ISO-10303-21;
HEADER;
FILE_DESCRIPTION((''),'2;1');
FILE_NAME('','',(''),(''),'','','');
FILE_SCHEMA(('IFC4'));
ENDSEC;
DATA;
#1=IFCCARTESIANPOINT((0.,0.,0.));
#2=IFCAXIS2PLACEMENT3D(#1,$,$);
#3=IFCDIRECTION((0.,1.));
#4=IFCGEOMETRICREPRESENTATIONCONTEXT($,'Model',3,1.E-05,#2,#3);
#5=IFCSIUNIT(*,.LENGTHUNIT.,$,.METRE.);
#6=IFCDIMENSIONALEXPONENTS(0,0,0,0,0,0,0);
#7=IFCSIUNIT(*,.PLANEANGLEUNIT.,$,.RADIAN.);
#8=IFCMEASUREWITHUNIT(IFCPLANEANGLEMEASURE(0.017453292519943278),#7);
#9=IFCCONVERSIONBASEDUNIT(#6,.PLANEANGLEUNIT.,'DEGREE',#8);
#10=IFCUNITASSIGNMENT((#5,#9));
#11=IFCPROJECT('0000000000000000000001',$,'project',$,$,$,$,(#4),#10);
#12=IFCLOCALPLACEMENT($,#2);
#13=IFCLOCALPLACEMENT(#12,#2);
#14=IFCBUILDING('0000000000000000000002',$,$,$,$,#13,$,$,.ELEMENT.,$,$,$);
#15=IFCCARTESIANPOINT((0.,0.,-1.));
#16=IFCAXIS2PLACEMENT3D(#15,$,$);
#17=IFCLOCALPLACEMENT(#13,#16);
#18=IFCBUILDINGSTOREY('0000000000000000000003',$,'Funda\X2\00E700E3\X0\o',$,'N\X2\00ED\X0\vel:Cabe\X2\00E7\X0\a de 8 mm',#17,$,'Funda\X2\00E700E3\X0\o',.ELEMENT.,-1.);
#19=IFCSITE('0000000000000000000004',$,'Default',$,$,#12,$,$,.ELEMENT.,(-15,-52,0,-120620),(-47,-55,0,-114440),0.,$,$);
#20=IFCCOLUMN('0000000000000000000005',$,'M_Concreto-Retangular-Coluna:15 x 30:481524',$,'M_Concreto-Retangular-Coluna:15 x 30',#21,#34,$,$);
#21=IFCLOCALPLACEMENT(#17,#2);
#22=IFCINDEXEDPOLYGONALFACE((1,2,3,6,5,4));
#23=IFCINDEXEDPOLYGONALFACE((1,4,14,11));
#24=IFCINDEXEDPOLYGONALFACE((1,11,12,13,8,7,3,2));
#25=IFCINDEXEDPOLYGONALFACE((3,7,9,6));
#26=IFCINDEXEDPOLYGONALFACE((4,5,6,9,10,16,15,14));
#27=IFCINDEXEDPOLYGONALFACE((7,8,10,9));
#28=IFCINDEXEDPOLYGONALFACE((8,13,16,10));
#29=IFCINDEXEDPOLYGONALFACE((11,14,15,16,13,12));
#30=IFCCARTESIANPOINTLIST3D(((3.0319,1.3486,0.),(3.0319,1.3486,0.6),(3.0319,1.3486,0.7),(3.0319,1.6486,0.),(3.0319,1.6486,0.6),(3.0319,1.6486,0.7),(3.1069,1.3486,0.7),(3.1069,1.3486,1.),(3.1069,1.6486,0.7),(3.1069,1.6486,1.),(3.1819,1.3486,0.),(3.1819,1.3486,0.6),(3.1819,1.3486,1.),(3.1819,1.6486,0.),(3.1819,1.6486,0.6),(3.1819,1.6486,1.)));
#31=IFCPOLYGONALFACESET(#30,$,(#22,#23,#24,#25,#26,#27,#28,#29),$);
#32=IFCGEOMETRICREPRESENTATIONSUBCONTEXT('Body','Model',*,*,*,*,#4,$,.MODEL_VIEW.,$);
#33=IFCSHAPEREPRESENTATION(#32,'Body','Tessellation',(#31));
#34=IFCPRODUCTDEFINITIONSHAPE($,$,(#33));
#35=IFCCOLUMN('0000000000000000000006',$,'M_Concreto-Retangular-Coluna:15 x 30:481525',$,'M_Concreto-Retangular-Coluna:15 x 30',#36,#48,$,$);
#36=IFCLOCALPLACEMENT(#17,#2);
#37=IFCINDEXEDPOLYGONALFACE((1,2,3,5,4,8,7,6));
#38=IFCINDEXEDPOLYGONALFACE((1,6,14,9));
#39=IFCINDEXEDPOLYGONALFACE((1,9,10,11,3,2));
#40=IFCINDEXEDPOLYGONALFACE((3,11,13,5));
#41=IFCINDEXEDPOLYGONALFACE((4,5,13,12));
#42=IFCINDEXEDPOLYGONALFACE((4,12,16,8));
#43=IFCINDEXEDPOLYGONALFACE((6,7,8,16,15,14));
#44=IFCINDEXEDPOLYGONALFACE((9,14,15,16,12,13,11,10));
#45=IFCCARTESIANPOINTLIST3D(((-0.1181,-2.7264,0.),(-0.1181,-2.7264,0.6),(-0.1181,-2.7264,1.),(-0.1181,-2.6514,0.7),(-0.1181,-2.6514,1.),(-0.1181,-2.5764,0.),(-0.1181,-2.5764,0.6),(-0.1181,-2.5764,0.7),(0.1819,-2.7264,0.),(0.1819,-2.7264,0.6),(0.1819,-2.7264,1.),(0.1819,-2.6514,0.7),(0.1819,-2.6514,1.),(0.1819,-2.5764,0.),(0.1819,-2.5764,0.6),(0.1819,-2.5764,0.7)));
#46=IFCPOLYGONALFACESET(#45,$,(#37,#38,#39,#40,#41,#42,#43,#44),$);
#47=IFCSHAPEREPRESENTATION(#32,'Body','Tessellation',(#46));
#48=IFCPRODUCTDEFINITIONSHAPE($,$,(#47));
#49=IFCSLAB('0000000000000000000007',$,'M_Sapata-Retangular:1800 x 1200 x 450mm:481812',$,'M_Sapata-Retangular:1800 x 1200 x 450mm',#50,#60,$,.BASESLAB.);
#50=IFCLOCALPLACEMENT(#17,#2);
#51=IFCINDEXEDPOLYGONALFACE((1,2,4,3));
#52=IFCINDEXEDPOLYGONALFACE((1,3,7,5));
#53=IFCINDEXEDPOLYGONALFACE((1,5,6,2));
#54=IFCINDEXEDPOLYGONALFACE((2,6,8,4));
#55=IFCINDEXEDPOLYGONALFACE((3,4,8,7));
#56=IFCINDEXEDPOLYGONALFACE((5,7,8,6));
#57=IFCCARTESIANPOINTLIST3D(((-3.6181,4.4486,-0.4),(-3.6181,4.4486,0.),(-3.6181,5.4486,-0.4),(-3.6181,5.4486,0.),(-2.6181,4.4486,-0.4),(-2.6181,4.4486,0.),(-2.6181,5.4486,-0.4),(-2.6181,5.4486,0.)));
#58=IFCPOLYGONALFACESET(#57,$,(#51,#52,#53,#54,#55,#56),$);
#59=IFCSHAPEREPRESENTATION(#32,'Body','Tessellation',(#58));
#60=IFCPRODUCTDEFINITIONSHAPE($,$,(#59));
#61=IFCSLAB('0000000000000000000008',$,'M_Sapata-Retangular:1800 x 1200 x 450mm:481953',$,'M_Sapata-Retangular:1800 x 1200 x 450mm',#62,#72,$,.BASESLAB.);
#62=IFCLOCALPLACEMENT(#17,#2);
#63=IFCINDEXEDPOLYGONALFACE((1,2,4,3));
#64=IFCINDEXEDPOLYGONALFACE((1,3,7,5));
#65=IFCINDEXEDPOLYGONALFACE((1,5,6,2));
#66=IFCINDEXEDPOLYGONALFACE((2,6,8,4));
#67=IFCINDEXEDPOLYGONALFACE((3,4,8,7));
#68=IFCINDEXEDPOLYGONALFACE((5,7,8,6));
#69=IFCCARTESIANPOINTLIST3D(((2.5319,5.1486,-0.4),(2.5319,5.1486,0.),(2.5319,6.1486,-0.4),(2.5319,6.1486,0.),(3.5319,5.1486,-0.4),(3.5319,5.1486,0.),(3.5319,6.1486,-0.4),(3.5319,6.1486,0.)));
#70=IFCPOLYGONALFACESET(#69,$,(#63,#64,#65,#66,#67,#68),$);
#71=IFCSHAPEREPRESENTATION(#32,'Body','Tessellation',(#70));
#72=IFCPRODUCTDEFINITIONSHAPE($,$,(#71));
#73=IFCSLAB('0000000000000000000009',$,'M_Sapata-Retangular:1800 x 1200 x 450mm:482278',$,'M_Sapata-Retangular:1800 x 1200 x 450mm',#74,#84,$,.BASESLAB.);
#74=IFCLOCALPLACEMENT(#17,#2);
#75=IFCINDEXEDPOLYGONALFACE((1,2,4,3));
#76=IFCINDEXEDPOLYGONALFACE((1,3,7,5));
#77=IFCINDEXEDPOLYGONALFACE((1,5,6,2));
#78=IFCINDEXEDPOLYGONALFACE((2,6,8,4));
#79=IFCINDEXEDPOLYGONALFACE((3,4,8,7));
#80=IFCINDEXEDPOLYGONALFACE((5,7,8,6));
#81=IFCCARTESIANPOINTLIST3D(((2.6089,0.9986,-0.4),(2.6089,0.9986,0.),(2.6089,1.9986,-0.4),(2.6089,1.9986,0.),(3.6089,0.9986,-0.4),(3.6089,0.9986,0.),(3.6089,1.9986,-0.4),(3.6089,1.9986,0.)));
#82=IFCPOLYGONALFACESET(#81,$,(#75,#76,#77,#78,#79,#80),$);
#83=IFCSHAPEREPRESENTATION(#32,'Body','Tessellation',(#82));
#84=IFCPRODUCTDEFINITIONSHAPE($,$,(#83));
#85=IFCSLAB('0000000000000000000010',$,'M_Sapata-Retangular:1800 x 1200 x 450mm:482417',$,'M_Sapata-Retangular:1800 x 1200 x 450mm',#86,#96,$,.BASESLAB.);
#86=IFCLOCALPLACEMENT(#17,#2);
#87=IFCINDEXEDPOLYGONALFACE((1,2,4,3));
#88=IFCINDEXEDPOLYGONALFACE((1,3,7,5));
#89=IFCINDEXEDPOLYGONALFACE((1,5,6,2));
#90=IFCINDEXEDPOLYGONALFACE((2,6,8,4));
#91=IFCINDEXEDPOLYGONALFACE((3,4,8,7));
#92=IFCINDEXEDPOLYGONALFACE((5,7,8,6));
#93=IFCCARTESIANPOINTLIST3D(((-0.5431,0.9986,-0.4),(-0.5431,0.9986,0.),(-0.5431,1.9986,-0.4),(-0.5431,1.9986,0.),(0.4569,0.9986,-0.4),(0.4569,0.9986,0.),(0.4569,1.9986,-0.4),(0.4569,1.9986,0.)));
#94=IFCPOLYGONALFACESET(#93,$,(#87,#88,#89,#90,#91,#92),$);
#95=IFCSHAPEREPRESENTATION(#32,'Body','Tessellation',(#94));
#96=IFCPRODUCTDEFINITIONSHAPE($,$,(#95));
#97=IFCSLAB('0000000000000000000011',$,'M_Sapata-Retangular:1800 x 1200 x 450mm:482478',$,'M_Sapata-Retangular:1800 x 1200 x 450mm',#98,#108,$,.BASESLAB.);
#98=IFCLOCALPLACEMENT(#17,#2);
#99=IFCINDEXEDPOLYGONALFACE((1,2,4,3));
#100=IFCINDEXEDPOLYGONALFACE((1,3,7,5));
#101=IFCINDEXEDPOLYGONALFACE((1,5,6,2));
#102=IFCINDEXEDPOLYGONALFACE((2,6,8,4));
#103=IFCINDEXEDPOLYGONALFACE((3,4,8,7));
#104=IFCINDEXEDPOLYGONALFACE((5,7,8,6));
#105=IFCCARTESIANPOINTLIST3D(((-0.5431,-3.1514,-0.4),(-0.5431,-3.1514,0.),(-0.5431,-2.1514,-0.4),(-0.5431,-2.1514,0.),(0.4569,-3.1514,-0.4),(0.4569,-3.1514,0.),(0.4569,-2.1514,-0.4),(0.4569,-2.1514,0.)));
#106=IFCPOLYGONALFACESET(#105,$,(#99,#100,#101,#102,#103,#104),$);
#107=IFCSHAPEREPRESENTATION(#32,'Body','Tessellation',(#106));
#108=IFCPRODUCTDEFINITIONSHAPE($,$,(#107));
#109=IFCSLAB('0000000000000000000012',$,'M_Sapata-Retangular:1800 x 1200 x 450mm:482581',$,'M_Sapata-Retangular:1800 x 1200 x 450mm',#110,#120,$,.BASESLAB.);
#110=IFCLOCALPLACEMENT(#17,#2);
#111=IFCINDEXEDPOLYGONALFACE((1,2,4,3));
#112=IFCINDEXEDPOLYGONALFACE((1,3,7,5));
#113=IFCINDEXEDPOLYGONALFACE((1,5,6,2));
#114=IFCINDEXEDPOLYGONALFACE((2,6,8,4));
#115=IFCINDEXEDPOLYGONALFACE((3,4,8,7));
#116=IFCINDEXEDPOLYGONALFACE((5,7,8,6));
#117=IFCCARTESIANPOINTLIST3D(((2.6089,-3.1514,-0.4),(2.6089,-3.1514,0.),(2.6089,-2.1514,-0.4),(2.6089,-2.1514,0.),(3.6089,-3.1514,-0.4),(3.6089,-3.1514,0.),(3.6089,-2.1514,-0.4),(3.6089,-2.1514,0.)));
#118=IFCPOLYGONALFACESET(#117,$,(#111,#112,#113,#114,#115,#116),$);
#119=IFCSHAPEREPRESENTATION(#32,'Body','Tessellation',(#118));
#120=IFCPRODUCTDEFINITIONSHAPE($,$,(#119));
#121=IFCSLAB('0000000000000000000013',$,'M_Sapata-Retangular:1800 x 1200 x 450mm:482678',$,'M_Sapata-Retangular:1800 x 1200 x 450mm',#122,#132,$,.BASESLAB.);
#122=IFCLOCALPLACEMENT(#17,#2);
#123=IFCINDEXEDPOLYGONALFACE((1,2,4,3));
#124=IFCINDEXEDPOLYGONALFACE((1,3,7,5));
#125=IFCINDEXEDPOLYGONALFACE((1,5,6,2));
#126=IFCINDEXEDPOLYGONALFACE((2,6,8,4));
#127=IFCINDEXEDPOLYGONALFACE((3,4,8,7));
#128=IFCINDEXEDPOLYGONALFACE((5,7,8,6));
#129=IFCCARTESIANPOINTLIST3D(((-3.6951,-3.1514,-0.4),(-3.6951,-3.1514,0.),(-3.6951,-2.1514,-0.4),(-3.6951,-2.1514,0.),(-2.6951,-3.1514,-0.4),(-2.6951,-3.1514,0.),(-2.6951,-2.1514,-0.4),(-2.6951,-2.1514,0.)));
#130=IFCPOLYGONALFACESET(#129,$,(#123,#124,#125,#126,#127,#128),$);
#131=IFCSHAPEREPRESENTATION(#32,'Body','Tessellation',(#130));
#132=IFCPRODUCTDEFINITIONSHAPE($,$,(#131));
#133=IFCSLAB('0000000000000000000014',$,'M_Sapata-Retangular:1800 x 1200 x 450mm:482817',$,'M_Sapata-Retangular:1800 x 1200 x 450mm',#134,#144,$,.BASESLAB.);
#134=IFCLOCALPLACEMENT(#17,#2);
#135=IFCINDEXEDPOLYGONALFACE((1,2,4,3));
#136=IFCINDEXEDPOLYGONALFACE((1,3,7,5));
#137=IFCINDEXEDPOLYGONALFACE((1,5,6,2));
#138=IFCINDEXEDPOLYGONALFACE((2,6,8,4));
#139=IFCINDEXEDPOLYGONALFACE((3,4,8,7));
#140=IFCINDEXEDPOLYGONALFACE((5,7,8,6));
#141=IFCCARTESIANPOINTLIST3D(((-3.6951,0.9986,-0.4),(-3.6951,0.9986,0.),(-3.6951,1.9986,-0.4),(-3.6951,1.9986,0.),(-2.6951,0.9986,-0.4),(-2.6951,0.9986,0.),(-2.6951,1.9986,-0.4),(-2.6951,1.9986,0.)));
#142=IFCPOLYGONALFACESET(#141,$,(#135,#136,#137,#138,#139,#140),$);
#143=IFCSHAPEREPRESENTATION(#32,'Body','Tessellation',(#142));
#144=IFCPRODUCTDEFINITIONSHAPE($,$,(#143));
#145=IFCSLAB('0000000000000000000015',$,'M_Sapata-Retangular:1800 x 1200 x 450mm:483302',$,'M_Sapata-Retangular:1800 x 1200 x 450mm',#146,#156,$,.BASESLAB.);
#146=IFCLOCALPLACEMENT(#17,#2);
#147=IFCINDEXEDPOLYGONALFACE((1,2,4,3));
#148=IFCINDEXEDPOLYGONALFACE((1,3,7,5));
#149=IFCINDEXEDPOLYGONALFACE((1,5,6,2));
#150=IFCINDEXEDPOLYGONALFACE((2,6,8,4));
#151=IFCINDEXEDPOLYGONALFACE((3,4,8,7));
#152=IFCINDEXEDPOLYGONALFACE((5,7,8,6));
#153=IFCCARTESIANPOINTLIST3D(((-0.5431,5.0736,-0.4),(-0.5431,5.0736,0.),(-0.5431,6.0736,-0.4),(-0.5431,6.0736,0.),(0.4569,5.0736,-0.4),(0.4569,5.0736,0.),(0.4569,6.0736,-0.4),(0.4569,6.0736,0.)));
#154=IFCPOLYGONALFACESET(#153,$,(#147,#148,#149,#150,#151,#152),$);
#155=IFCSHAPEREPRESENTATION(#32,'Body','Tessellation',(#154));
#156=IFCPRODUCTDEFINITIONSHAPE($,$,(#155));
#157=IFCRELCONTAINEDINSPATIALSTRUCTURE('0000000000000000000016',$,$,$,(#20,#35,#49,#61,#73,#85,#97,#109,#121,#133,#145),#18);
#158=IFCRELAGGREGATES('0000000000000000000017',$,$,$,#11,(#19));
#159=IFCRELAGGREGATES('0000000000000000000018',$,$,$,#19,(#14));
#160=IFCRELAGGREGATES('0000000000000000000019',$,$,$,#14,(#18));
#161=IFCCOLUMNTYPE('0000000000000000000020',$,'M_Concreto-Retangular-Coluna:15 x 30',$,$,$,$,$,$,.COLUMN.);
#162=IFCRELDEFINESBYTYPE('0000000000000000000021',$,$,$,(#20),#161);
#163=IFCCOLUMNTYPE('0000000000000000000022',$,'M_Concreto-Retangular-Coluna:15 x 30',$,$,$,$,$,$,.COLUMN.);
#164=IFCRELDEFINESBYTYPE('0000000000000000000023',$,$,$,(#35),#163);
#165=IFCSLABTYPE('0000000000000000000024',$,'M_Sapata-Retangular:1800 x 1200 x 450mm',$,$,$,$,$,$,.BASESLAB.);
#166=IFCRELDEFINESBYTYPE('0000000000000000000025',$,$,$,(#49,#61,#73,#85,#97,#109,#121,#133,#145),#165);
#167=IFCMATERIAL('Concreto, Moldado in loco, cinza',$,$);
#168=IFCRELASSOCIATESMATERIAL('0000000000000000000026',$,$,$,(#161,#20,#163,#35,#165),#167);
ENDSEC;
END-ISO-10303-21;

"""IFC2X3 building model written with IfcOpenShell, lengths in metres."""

from ifc_helpers import new_model, entity, si_unit, converted_unit, direction, frame, frame_2d, origin, origin_2d_with_axis, place, context, subcontext, project, spatial, polyline, rectangle, outline, extrude, source, transform, mapped, material, type_object, type_shapes, element, save


model = new_model("IFC2X3")

# Units and contexts
model_context = context("Model", 3, precision=1e-05, world=origin(), true_north=direction((0.0, 1.0)))
body_context = subcontext(model_context, "Body", "Model", "MODEL_VIEW")
ifc_project = project(units=[si_unit("LENGTHUNIT", "METRE"), converted_unit("PLANEANGLEUNIT", "DEGREE", entity("IfcPlaneAngleMeasure", 0.017453292519943278), si_unit("PLANEANGLEUNIT", "RADIAN"), dimensions=[0, 0, 0, 0, 0, 0, 0])], contexts=[model_context])

# Site, building, storey
site_placement = place(None, origin())
site = spatial("IfcSite", under=ifc_project, at=site_placement, Name="Default", CompositionType="ELEMENT", RefLatitude=(-15, -52, 0, -120620), RefLongitude=(-47, -55, 0, -114440), RefElevation=0.0)
building_placement = place(site_placement, origin())
building = spatial("IfcBuilding", under=site, at=building_placement, CompositionType="ELEMENT")
storey_placement = place(building_placement, frame((0.0, 0.0, -1.0)))
storey = spatial("IfcBuildingStorey", under=building, at=storey_placement, Name="Fundação", ObjectType="Nível:Cabeça de 8 mm", LongName="Fundação", CompositionType="ELEMENT", Elevation=-1.0)

# Columns
ifc_material = material(Name="Concreto, Moldado in loco, cinza")
column_type_1 = type_object("IfcColumnType", Name="M_Concreto-Retangular-Coluna:15 x 30", PredefinedType="COLUMN", material=ifc_material)
shared_shape_1 = source(origin(), body_context, "Body", "SweptSolid", [
    extrude(outline(polyline([(-0.575, -0.075), (0.025, -0.075), (0.125, -0.075), (0.125, 0.0), (0.425, 0.0), (0.425, 0.075), (0.025, 0.075), (-0.575, 0.075), (-0.575, -0.075)])), frame((3.1069, 1.3486, -0.425), z_axis=(0.0, 1.0, 0.0), x_axis=(0.0, 0.0, 1.0)), (0.0, 0.0, 1.0), 0.3),
])
type_shapes(column_type_1, [shared_shape_1])
column_1_placement = place(storey_placement, frame((0.0, 0.0, 1.0)))
element("IfcColumn", 1, at=column_1_placement, inside=storey, type_object=column_type_1, material=ifc_material, Name="M_Concreto-Retangular-Coluna:15 x 30:481524", ObjectType="M_Concreto-Retangular-Coluna:15 x 30", context=body_context, shape_type="MappedRepresentation", body=[
    mapped(shared_shape_1, transform((0.0, 0.0, 0.0), scale=1.0)),
])
column_type_2 = type_object("IfcColumnType", Name="M_Concreto-Retangular-Coluna:15 x 30", PredefinedType="COLUMN", material=ifc_material)
shared_shape_2 = source(origin(), body_context, "Body", "SweptSolid", [
    extrude(outline(polyline([(-0.575, -0.075), (0.025, -0.075), (0.125, -0.075), (0.125, 0.0), (0.425, 0.0), (0.425, 0.075), (0.025, 0.075), (-0.575, 0.075), (-0.575, -0.075)])), frame((-0.1181, -2.6514, -0.425), z_axis=(1.0, 0.0, 0.0), x_axis=(0.0, 0.0, 1.0)), (0.0, 0.0, 1.0), 0.3),
])
type_shapes(column_type_2, [shared_shape_2])
column_2_placement = place(storey_placement, frame((0.0, 0.0, 1.0)))
element("IfcColumn", 2, at=column_2_placement, inside=storey, type_object=column_type_2, material=ifc_material, Name="M_Concreto-Retangular-Coluna:15 x 30:481525", ObjectType="M_Concreto-Retangular-Coluna:15 x 30", context=body_context, shape_type="MappedRepresentation", body=[
    mapped(shared_shape_2, transform((0.0, 0.0, 0.0), scale=1.0)),
])

# Slabs
slab_type = type_object("IfcSlabType", Name="M_Sapata-Retangular:1800 x 1200 x 450mm", PredefinedType="BASESLAB", material=ifc_material)
slab_1_placement = place(storey_placement, origin())
element("IfcSlab", 3, at=slab_1_placement, inside=storey, type_object=slab_type, Name="M_Sapata-Retangular:1800 x 1200 x 450mm:481812", ObjectType="M_Sapata-Retangular:1800 x 1200 x 450mm", PredefinedType="BASESLAB", context=body_context, shape_type="SweptSolid", body=[
    extrude(rectangle(XDim=1.0, YDim=1.0, at=frame_2d((0.0, 0.0), x_axis=(1.0, 0.0))), frame((-3.1181, 4.9486, -0.4), z_axis=(0.0, 0.0, 1.0), x_axis=(-1.0, 0.0, 0.0)), (0.0, 0.0, 1.0), 0.4),
])
slab_2_placement = place(storey_placement, origin())
element("IfcSlab", 4, at=slab_2_placement, inside=storey, type_object=slab_type, Name="M_Sapata-Retangular:1800 x 1200 x 450mm:481953", ObjectType="M_Sapata-Retangular:1800 x 1200 x 450mm", PredefinedType="BASESLAB", context=body_context, shape_type="SweptSolid", body=[
    extrude(rectangle(XDim=1.0, YDim=1.0, at=frame_2d((0.0, 0.0), x_axis=(1.0, 0.0))), frame((3.0319, 5.6486, -0.4), z_axis=(0.0, 0.0, 1.0), x_axis=(-1.0, 0.0, 0.0)), (0.0, 0.0, 1.0), 0.4),
])
slab_3_placement = place(storey_placement, origin())
element("IfcSlab", 5, at=slab_3_placement, inside=storey, type_object=slab_type, Name="M_Sapata-Retangular:1800 x 1200 x 450mm:482278", ObjectType="M_Sapata-Retangular:1800 x 1200 x 450mm", PredefinedType="BASESLAB", context=body_context, shape_type="SweptSolid", body=[
    extrude(rectangle(XDim=1.0, YDim=1.0, at=frame_2d((0.0, 0.0), x_axis=(1.0, 0.0))), frame((3.1089, 1.4986, -0.4), z_axis=(0.0, 0.0, 1.0), x_axis=(-1.0, 0.0, 0.0)), (0.0, 0.0, 1.0), 0.4),
])
slab_4_placement = place(storey_placement, origin())
element("IfcSlab", 6, at=slab_4_placement, inside=storey, type_object=slab_type, Name="M_Sapata-Retangular:1800 x 1200 x 450mm:482417", ObjectType="M_Sapata-Retangular:1800 x 1200 x 450mm", PredefinedType="BASESLAB", context=body_context, shape_type="SweptSolid", body=[
    extrude(rectangle(XDim=1.0, YDim=1.0, at=frame_2d((0.0, 0.0), x_axis=(1.0, 0.0))), frame((-0.0431, 1.4986, -0.4), z_axis=(0.0, 0.0, 1.0), x_axis=(-1.0, 0.0, 0.0)), (0.0, 0.0, 1.0), 0.4),
])
slab_5_placement = place(storey_placement, origin())
element("IfcSlab", 7, at=slab_5_placement, inside=storey, type_object=slab_type, Name="M_Sapata-Retangular:1800 x 1200 x 450mm:482478", ObjectType="M_Sapata-Retangular:1800 x 1200 x 450mm", PredefinedType="BASESLAB", context=body_context, shape_type="SweptSolid", body=[
    extrude(rectangle(XDim=1.0, YDim=1.0, at=frame_2d((0.0, 0.0), x_axis=(1.0, 0.0))), frame((-0.0431, -2.6514, -0.4), z_axis=(0.0, 0.0, 1.0), x_axis=(-1.0, 0.0, 0.0)), (0.0, 0.0, 1.0), 0.4),
])
slab_6_placement = place(storey_placement, origin())
element("IfcSlab", 8, at=slab_6_placement, inside=storey, type_object=slab_type, Name="M_Sapata-Retangular:1800 x 1200 x 450mm:482581", ObjectType="M_Sapata-Retangular:1800 x 1200 x 450mm", PredefinedType="BASESLAB", context=body_context, shape_type="SweptSolid", body=[
    extrude(rectangle(XDim=1.0, YDim=1.0, at=frame_2d((0.0, 0.0), x_axis=(1.0, 0.0))), frame((3.1089, -2.6514, -0.4), z_axis=(0.0, 0.0, 1.0), x_axis=(-1.0, 0.0, 0.0)), (0.0, 0.0, 1.0), 0.4),
])
slab_7_placement = place(storey_placement, origin())
element("IfcSlab", 9, at=slab_7_placement, inside=storey, type_object=slab_type, Name="M_Sapata-Retangular:1800 x 1200 x 450mm:482678", ObjectType="M_Sapata-Retangular:1800 x 1200 x 450mm", PredefinedType="BASESLAB", context=body_context, shape_type="SweptSolid", body=[
    extrude(rectangle(XDim=1.0, YDim=1.0, at=frame_2d((0.0, 0.0), x_axis=(1.0, 0.0))), frame((-3.1951, -2.6514, -0.4), z_axis=(0.0, 0.0, 1.0), x_axis=(-1.0, 0.0, 0.0)), (0.0, 0.0, 1.0), 0.4),
])
slab_8_placement = place(storey_placement, origin())
element("IfcSlab", 10, at=slab_8_placement, inside=storey, type_object=slab_type, Name="M_Sapata-Retangular:1800 x 1200 x 450mm:482817", ObjectType="M_Sapata-Retangular:1800 x 1200 x 450mm", PredefinedType="BASESLAB", context=body_context, shape_type="SweptSolid", body=[
    extrude(rectangle(XDim=1.0, YDim=1.0, at=frame_2d((0.0, 0.0), x_axis=(1.0, 0.0))), frame((-3.1951, 1.4986, -0.4), z_axis=(0.0, 0.0, 1.0), x_axis=(-1.0, 0.0, 0.0)), (0.0, 0.0, 1.0), 0.4),
])
slab_9_placement = place(storey_placement, origin())
element("IfcSlab", 11, at=slab_9_placement, inside=storey, type_object=slab_type, Name="M_Sapata-Retangular:1800 x 1200 x 450mm:483302", ObjectType="M_Sapata-Retangular:1800 x 1200 x 450mm", PredefinedType="BASESLAB", context=body_context, shape_type="SweptSolid", body=[
    extrude(rectangle(XDim=1.0, YDim=1.0, at=origin_2d_with_axis()), frame((-0.0431, 5.5736, -0.4), z_axis=(0.0, 0.0, 1.0), x_axis=(-1.0, 0.0, 0.0)), (0.0, 0.0, 1.0), 0.4),
])

save(model, "model.ifc")
